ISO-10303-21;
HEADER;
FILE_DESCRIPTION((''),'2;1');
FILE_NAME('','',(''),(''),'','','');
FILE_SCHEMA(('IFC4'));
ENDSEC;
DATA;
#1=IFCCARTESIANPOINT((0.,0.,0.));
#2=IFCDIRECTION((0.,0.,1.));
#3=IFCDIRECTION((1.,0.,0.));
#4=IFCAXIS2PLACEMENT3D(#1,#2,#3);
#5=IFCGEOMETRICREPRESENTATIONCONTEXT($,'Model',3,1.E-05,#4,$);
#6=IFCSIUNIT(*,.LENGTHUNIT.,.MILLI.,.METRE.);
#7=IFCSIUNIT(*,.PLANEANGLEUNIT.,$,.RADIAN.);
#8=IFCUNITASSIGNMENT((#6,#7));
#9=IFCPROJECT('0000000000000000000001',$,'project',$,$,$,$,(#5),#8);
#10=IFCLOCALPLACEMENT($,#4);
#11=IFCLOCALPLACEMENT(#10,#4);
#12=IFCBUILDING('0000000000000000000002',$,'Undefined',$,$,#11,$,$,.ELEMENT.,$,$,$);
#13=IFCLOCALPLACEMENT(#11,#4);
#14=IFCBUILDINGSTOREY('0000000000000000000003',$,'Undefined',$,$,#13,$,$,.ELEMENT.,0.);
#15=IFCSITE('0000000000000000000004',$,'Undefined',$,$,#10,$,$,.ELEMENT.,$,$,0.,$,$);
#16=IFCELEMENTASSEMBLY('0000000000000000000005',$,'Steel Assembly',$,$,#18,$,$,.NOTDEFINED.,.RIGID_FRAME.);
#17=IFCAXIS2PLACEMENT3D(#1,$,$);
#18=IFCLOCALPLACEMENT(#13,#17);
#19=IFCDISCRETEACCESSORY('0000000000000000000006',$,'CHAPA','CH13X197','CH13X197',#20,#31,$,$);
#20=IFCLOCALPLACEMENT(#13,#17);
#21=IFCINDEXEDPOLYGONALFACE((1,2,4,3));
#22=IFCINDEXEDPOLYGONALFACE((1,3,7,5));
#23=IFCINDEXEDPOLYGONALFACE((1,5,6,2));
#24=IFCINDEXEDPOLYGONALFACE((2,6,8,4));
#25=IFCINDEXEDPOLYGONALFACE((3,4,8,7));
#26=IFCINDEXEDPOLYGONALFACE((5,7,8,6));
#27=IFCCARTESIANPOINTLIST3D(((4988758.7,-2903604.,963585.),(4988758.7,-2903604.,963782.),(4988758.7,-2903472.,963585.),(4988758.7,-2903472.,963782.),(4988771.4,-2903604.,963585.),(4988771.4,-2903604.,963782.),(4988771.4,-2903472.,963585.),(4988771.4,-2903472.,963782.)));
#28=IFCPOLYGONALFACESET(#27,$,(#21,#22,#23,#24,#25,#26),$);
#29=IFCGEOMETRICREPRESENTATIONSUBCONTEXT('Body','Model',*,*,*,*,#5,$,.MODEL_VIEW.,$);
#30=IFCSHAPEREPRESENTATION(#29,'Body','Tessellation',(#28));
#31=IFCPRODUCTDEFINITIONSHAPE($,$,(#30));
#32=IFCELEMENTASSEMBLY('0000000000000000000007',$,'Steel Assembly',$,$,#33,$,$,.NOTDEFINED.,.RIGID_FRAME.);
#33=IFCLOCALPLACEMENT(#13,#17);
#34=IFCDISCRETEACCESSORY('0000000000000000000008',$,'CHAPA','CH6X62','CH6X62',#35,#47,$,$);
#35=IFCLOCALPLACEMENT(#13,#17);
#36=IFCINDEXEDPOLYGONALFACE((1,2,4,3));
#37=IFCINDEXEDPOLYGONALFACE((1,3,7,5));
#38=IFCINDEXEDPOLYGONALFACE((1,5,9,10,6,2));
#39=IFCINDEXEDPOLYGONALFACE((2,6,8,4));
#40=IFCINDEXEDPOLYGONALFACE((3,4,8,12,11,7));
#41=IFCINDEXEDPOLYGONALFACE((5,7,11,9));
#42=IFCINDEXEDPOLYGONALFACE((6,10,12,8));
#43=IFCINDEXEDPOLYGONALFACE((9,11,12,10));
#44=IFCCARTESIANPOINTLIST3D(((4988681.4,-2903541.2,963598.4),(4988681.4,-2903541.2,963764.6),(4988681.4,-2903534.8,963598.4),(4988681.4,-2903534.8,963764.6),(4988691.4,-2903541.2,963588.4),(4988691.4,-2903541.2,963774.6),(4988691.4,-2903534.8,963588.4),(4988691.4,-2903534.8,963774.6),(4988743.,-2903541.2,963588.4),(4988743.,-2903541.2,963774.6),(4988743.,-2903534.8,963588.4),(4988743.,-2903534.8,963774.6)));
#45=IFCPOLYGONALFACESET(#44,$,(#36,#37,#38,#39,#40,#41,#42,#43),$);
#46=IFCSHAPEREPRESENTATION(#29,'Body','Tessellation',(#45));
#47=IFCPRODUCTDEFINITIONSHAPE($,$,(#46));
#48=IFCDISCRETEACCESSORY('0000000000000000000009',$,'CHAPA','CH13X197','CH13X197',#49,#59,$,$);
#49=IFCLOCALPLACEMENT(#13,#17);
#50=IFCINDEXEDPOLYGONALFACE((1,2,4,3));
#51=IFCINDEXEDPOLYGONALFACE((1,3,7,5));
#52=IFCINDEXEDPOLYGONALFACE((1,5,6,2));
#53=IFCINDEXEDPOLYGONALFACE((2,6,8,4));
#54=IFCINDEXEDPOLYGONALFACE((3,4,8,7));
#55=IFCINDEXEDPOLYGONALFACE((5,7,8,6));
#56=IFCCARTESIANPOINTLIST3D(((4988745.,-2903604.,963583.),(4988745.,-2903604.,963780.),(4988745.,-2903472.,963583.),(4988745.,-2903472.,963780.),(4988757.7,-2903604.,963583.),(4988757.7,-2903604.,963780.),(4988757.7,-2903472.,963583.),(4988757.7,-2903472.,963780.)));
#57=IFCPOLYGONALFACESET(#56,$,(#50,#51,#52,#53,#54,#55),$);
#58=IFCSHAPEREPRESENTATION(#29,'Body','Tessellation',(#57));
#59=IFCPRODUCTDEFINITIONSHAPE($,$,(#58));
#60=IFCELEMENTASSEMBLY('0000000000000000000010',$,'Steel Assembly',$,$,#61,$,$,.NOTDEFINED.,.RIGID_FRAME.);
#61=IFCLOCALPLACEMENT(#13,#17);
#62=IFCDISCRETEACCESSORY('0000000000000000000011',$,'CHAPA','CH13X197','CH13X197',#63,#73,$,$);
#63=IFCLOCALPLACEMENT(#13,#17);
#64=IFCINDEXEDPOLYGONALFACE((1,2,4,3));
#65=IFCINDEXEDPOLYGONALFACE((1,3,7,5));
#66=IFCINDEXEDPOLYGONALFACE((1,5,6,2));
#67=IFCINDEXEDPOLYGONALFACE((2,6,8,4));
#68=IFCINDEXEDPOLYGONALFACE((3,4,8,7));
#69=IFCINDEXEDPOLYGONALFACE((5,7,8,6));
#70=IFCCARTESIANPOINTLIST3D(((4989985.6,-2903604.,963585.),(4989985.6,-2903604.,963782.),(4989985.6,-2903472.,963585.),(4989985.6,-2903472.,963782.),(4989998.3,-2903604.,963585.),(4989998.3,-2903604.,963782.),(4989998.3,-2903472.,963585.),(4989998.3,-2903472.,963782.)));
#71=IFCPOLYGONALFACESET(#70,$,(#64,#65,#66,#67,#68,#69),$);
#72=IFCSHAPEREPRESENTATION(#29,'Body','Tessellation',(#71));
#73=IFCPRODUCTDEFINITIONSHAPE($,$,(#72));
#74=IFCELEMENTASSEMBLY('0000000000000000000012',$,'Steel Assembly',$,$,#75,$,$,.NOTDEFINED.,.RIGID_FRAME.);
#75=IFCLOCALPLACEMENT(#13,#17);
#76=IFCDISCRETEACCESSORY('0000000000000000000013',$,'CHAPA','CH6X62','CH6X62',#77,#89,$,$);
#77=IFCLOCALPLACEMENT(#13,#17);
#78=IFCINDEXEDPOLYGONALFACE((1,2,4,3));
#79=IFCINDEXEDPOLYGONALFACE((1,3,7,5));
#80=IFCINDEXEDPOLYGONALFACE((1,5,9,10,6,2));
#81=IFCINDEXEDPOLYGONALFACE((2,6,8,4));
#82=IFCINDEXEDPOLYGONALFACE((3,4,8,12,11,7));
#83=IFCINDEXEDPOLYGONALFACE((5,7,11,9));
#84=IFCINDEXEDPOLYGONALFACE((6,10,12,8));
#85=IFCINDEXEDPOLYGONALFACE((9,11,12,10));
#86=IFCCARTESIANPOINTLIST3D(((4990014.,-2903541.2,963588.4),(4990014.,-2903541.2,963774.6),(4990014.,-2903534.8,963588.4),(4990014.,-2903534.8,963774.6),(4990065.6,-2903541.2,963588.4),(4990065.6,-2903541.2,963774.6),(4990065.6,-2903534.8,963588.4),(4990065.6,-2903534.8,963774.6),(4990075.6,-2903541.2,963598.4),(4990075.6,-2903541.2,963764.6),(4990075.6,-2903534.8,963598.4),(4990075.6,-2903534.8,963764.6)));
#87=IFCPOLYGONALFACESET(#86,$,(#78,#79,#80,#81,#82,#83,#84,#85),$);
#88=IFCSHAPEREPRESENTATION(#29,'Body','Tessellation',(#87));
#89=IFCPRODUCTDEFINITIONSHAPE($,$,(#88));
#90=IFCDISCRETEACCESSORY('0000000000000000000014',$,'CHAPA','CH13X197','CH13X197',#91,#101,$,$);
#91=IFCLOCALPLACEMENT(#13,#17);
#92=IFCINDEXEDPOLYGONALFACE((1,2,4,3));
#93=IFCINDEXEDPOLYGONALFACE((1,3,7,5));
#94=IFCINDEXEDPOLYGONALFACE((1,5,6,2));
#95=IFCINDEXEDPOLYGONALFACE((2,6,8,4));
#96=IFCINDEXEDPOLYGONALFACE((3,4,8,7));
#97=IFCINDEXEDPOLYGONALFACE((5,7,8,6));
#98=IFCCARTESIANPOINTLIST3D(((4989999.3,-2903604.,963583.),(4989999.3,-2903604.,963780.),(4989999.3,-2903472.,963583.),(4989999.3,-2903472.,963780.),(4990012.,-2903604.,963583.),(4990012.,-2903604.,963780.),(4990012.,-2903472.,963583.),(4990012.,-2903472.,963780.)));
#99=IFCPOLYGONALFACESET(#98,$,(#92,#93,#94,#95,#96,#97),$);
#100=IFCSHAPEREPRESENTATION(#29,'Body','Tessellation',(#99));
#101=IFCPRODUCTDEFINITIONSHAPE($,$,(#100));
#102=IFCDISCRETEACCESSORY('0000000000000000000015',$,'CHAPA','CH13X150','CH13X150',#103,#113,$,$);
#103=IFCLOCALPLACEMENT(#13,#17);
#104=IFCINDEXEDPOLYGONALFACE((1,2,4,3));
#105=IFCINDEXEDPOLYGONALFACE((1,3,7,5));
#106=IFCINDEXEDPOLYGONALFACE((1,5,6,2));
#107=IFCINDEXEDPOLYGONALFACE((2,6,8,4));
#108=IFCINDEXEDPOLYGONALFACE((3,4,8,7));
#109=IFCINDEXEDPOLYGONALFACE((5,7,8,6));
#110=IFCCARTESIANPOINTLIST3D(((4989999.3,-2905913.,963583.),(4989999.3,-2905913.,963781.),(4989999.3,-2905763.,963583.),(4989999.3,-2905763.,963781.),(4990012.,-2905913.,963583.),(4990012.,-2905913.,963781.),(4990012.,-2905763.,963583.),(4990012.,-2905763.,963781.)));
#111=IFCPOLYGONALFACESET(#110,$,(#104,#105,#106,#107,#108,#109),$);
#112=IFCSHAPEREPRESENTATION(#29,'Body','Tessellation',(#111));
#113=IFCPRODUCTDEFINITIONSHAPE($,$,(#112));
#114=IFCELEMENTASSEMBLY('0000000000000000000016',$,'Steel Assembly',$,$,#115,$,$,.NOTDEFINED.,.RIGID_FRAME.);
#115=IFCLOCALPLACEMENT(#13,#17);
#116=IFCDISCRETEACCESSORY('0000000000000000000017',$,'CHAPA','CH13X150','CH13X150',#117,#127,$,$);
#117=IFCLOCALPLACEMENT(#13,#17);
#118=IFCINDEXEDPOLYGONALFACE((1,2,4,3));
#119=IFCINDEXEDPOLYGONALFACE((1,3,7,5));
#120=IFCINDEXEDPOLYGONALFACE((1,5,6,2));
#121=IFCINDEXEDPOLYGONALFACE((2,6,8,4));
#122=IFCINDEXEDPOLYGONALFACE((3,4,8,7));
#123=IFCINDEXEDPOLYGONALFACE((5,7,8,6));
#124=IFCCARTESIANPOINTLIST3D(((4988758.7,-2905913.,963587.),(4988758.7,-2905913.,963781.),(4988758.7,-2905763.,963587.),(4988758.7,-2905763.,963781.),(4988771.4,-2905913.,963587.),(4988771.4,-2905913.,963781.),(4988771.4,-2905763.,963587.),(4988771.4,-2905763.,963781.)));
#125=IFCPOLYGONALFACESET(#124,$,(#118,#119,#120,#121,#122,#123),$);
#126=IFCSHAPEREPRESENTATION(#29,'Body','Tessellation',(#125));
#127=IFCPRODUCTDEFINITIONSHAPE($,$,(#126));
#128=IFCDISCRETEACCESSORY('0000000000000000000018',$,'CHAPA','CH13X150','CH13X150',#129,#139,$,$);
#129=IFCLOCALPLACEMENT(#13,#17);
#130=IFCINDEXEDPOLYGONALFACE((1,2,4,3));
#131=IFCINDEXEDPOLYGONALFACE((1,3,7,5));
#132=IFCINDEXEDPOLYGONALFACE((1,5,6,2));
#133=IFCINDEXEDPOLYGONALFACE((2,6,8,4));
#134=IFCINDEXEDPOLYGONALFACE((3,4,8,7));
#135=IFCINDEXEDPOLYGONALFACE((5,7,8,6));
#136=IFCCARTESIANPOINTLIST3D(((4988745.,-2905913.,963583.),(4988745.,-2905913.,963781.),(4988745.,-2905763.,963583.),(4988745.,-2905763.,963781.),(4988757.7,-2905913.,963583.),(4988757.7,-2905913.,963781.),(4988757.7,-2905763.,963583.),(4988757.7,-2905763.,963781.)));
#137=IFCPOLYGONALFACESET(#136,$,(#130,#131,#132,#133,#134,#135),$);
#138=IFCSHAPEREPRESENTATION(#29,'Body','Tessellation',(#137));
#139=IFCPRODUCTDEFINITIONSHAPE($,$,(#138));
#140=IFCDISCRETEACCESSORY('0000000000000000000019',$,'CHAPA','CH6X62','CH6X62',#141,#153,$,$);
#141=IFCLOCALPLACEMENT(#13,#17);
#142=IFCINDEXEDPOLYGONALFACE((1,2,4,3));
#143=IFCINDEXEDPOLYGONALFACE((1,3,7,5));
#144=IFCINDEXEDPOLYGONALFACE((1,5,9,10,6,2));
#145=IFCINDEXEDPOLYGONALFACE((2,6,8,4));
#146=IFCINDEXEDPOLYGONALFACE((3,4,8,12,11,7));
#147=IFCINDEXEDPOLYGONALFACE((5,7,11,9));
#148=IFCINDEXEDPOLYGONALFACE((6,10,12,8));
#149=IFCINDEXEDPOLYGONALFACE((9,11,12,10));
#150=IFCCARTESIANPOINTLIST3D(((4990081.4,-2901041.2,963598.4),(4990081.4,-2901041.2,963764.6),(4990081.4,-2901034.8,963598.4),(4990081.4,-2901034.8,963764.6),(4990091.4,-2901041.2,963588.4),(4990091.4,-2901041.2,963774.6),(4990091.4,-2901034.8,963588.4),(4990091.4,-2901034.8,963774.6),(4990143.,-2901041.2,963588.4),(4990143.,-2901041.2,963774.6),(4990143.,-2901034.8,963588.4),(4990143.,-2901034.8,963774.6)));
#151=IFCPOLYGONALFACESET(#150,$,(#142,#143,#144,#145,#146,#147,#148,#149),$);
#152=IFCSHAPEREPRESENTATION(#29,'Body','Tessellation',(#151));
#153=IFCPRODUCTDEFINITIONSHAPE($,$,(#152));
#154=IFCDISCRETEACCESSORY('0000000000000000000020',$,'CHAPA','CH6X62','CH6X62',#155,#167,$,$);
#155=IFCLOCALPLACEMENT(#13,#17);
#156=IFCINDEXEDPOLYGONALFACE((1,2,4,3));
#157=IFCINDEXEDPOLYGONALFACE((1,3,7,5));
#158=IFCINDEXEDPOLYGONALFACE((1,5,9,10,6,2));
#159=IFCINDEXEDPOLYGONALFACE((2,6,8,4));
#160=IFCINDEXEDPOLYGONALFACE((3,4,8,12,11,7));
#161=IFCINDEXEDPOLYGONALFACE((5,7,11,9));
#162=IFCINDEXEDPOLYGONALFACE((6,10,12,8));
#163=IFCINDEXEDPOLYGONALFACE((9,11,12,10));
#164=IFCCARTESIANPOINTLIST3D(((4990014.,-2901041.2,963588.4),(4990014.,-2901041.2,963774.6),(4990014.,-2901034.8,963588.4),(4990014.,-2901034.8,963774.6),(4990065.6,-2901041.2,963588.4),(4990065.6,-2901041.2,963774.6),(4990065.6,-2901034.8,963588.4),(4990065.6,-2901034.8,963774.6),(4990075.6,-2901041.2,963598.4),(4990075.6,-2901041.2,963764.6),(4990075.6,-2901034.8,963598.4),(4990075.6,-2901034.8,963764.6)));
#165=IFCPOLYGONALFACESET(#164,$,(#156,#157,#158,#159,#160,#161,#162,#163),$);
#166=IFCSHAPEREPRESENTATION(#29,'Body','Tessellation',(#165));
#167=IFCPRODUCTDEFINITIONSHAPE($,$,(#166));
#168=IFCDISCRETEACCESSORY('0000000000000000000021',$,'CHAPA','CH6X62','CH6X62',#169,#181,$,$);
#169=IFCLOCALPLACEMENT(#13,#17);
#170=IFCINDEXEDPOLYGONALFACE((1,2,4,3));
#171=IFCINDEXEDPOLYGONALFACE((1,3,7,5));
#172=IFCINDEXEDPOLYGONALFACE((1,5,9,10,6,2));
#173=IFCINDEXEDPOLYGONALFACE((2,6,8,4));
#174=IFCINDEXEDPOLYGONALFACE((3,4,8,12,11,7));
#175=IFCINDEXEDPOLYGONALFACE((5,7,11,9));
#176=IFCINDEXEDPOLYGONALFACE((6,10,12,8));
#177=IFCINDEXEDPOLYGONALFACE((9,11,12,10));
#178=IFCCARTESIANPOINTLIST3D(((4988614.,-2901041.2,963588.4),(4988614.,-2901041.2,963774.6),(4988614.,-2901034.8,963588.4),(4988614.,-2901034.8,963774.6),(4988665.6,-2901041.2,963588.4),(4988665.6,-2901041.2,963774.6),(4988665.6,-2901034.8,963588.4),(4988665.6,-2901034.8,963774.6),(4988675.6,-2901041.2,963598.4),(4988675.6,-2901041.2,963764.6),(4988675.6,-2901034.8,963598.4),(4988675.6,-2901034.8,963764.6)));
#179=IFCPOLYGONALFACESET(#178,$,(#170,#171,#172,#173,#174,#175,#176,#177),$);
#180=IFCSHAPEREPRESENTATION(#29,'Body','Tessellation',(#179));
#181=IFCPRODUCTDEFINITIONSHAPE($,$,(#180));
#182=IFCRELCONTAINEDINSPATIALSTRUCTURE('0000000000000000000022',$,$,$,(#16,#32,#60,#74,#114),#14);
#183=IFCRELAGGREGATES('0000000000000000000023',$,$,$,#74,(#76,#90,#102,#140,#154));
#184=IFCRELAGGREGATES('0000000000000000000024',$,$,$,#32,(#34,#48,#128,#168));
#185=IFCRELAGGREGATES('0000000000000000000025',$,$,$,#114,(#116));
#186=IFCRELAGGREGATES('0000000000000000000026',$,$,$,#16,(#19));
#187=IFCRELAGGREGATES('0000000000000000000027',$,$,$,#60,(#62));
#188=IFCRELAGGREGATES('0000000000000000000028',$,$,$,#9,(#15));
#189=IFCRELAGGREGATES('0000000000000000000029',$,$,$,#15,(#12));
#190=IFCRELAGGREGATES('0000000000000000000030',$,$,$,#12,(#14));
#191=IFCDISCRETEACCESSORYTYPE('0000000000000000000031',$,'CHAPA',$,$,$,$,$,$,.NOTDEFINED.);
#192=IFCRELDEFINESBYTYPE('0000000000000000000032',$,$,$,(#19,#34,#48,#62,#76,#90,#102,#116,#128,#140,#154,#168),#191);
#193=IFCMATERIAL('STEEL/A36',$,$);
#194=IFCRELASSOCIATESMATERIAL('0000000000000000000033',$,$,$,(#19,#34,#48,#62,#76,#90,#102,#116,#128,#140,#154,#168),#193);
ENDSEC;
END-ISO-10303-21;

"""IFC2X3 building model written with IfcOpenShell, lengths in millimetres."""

from ifc_helpers import new_model, si_unit, frame, origin_with_axes, place, context, subcontext, project, spatial, polyline, outline, extrude, material, type_object, element, aggregate, save


model = new_model("IFC2X3")

# Units and contexts
model_context = context("Model", 3, precision=1e-05, world=origin_with_axes())
body_context = subcontext(model_context, "Body", "Model", "MODEL_VIEW")
ifc_project = project(units=[si_unit("LENGTHUNIT", "METRE", prefix="MILLI"), si_unit("PLANEANGLEUNIT", "RADIAN")], contexts=[model_context])

# Site, building, storey
site_placement = place(None, origin_with_axes())
site = spatial("IfcSite", under=ifc_project, at=site_placement, Name="Undefined", CompositionType="ELEMENT", RefElevation=0.0)
building_placement = place(site_placement, origin_with_axes())
building = spatial("IfcBuilding", under=site, at=building_placement, Name="Undefined", CompositionType="ELEMENT")
storey_placement = place(building_placement, origin_with_axes())
storey = spatial("IfcBuildingStorey", under=building, at=storey_placement, Name="Undefined", CompositionType="ELEMENT", Elevation=0.0)

# Element assembly, discrete accessory
assembly_1_placement = place(storey_placement, origin_with_axes())
assembly_1 = element("IfcElementAssembly", 1, at=assembly_1_placement, inside=storey, Name="Steel Assembly", AssemblyPlace="NOTDEFINED", PredefinedType="RIGID_FRAME")
ifc_material = material(Name="STEEL/A36")
discrete_accessory_type = type_object("IfcDiscreteAccessoryType", Name="CHAPA")
discrete_accessory_1_placement = place(assembly_1_placement, frame((4988765.0, -2903538.0, 963782.0), z_axis=(1.0, 0.0, 0.0), x_axis=(0.0, 0.0, -1.0)))
discrete_accessory_1 = element("IfcDiscreteAccessory", 2, at=discrete_accessory_1_placement, type_object=discrete_accessory_type, material=ifc_material, Name="CHAPA", Description="CH13X197", ObjectType="CH13X197", context=body_context, shape_type="SweptSolid", body=[
    extrude(outline(polyline([(197.0, -66.0), (0.0, -66.0), (0.0, 66.0), (197.0, 66.0), (197.0, -66.0)])), frame((0.0, 0.0, -6.3), z_axis=(0.0, 0.0, 1.0), x_axis=(1.0, 0.0, 0.0)), (0.0, 0.0, 1.0), 12.7),
])

# Element assembly, discrete accessories
assembly_2_placement = place(storey_placement, origin_with_axes())
assembly_2 = element("IfcElementAssembly", 3, at=assembly_2_placement, inside=storey, Name="Steel Assembly", AssemblyPlace="NOTDEFINED", PredefinedType="RIGID_FRAME")
discrete_accessory_2_placement = place(assembly_2_placement, frame((4988681.4, -2903538.0, 963774.6), z_axis=(0.0, 1.0, 0.0), x_axis=(1.0, 0.0, 0.0)))
discrete_accessory_2 = element("IfcDiscreteAccessory", 4, at=discrete_accessory_2_placement, type_object=discrete_accessory_type, material=ifc_material, Name="CHAPA", Description="CH6X62", ObjectType="CH6X62", context=body_context, shape_type="SweptSolid", body=[
    extrude(outline(polyline([(0.0, 10.0), (10.0, 0.0), (61.6, 0.0), (61.6, 186.2), (10.0, 186.2), (0.0, 176.2), (0.0, 10.0)])), frame((0.0, 0.0, -3.2), z_axis=(0.0, 0.0, 1.0), x_axis=(1.0, 0.0, 0.0)), (0.0, 0.0, 1.0), 6.4),
])
discrete_accessory_3_placement = place(assembly_2_placement, frame((4988751.3, -2903538.0, 963780.0), z_axis=(1.0, 0.0, 0.0), x_axis=(0.0, 0.0, -1.0)))
discrete_accessory_3 = element("IfcDiscreteAccessory", 5, at=discrete_accessory_3_placement, type_object=discrete_accessory_type, material=ifc_material, Name="CHAPA", Description="CH13X197", ObjectType="CH13X197", context=body_context, shape_type="SweptSolid", body=[
    extrude(outline(polyline([(197.0, -66.0), (0.0, -66.0), (0.0, 66.0), (197.0, 66.0), (197.0, -66.0)])), frame((0.0, 0.0, -6.3), z_axis=(0.0, 0.0, 1.0), x_axis=(1.0, 0.0, 0.0)), (0.0, 0.0, 1.0), 12.7),
])

# Element assembly, discrete accessory
assembly_3_placement = place(storey_placement, origin_with_axes())
assembly_3 = element("IfcElementAssembly", 6, at=assembly_3_placement, inside=storey, Name="Steel Assembly", AssemblyPlace="NOTDEFINED", PredefinedType="RIGID_FRAME")
discrete_accessory_4_placement = place(assembly_3_placement, frame((4989991.9, -2903538.0, 963782.0), z_axis=(-1.0, 0.0, 0.0), x_axis=(0.0, 0.0, -1.0)))
discrete_accessory_4 = element("IfcDiscreteAccessory", 7, at=discrete_accessory_4_placement, type_object=discrete_accessory_type, material=ifc_material, Name="CHAPA", Description="CH13X197", ObjectType="CH13X197", context=body_context, shape_type="SweptSolid", body=[
    extrude(outline(polyline([(197.0, 66.0), (197.0, -66.0), (0.0, -66.0), (0.0, 66.0), (197.0, 66.0)])), frame((0.0, 0.0, -6.3), z_axis=(0.0, 0.0, 1.0), x_axis=(1.0, 0.0, 0.0)), (0.0, 0.0, 1.0), 12.7),
])

# Element assembly, discrete accessories
assembly_4_placement = place(storey_placement, origin_with_axes())
assembly_4 = element("IfcElementAssembly", 8, at=assembly_4_placement, inside=storey, Name="Steel Assembly", AssemblyPlace="NOTDEFINED", PredefinedType="RIGID_FRAME")
discrete_accessory_5_placement = place(assembly_4_placement, frame((4990075.6, -2903538.0, 963774.6), z_axis=(0.0, -1.0, 0.0), x_axis=(-1.0, 0.0, 0.0)))
discrete_accessory_5 = element("IfcDiscreteAccessory", 9, at=discrete_accessory_5_placement, type_object=discrete_accessory_type, material=ifc_material, Name="CHAPA", Description="CH6X62", ObjectType="CH6X62", context=body_context, shape_type="SweptSolid", body=[
    extrude(outline(polyline([(0.0, 10.0), (10.0, 0.0), (61.6, 0.0), (61.6, 186.2), (10.0, 186.2), (0.0, 176.2), (0.0, 10.0)])), frame((0.0, 0.0, -3.2), z_axis=(0.0, 0.0, 1.0), x_axis=(1.0, 0.0, 0.0)), (0.0, 0.0, 1.0), 6.4),
])
discrete_accessory_6_placement = place(assembly_4_placement, frame((4990005.6, -2903538.0, 963780.0), z_axis=(-1.0, 0.0, 0.0), x_axis=(0.0, 0.0, -1.0)))
discrete_accessory_6 = element("IfcDiscreteAccessory", 10, at=discrete_accessory_6_placement, type_object=discrete_accessory_type, material=ifc_material, Name="CHAPA", Description="CH13X197", ObjectType="CH13X197", context=body_context, shape_type="SweptSolid", body=[
    extrude(outline(polyline([(197.0, 66.0), (197.0, -66.0), (0.0, -66.0), (0.0, 66.0), (197.0, 66.0)])), frame((0.0, 0.0, -6.3), z_axis=(0.0, 0.0, 1.0), x_axis=(1.0, 0.0, 0.0)), (0.0, 0.0, 1.0), 12.7),
])
discrete_accessory_7_placement = place(assembly_4_placement, frame((4990005.6, -2905838.0, 963781.0), z_axis=(-1.0, 0.0, 0.0), x_axis=(0.0, 0.0, -1.0)))
discrete_accessory_7 = element("IfcDiscreteAccessory", 11, at=discrete_accessory_7_placement, type_object=discrete_accessory_type, material=ifc_material, Name="CHAPA", Description="CH13X150", ObjectType="CH13X150", context=body_context, shape_type="SweptSolid", body=[
    extrude(outline(polyline([(198.0, 75.0), (198.0, -75.0), (0.0, -75.0), (0.0, 75.0), (198.0, 75.0)])), frame((0.0, 0.0, -6.3), z_axis=(0.0, 0.0, 1.0), x_axis=(1.0, 0.0, 0.0)), (0.0, 0.0, 1.0), 12.7),
])

# Element assembly, discrete accessory
assembly_5_placement = place(storey_placement, origin_with_axes())
assembly_5 = element("IfcElementAssembly", 12, at=assembly_5_placement, inside=storey, Name="Steel Assembly", AssemblyPlace="NOTDEFINED", PredefinedType="RIGID_FRAME")
discrete_accessory_8_placement = place(assembly_5_placement, frame((4988765.0, -2905838.0, 963781.0), z_axis=(1.0, 0.0, 0.0), x_axis=(0.0, 0.0, -1.0)))
discrete_accessory_8 = element("IfcDiscreteAccessory", 13, at=discrete_accessory_8_placement, type_object=discrete_accessory_type, material=ifc_material, Name="CHAPA", Description="CH13X150", ObjectType="CH13X150", context=body_context, shape_type="SweptSolid", body=[
    extrude(outline(polyline([(194.0, -75.0), (0.0, -75.0), (0.0, 75.0), (194.0, 75.0), (194.0, -75.0)])), frame((0.0, 0.0, -6.3), z_axis=(0.0, 0.0, 1.0), x_axis=(1.0, 0.0, 0.0)), (0.0, 0.0, 1.0), 12.7),
])

# Discrete accessories
discrete_accessory_9_placement = place(assembly_2_placement, frame((4988751.3, -2905838.0, 963781.0), z_axis=(1.0, 0.0, 0.0), x_axis=(0.0, 0.0, -1.0)))
discrete_accessory_9 = element("IfcDiscreteAccessory", 14, at=discrete_accessory_9_placement, type_object=discrete_accessory_type, material=ifc_material, Name="CHAPA", Description="CH13X150", ObjectType="CH13X150", context=body_context, shape_type="SweptSolid", body=[
    extrude(outline(polyline([(198.0, -75.0), (0.0, -75.0), (0.0, 75.0), (198.0, 75.0), (198.0, -75.0)])), frame((0.0, 0.0, -6.3), z_axis=(0.0, 0.0, 1.0), x_axis=(1.0, 0.0, 0.0)), (0.0, 0.0, 1.0), 12.7),
])
discrete_accessory_10_placement = place(assembly_4_placement, frame((4990081.4, -2901038.0, 963774.6), z_axis=(0.0, 1.0, 0.0), x_axis=(1.0, 0.0, 0.0)))
discrete_accessory_10 = element("IfcDiscreteAccessory", 15, at=discrete_accessory_10_placement, type_object=discrete_accessory_type, material=ifc_material, Name="CHAPA", Description="CH6X62", ObjectType="CH6X62", context=body_context, shape_type="SweptSolid", body=[
    extrude(outline(polyline([(0.0, 10.0), (10.0, 0.0), (61.6, 0.0), (61.6, 186.2), (10.0, 186.2), (0.0, 176.2), (0.0, 10.0)])), frame((0.0, 0.0, -3.2), z_axis=(0.0, 0.0, 1.0), x_axis=(1.0, 0.0, 0.0)), (0.0, 0.0, 1.0), 6.4),
])
discrete_accessory_11_placement = place(assembly_4_placement, frame((4990075.6, -2901038.0, 963774.6), z_axis=(0.0, -1.0, 0.0), x_axis=(-1.0, 0.0, 0.0)))
discrete_accessory_11 = element("IfcDiscreteAccessory", 16, at=discrete_accessory_11_placement, type_object=discrete_accessory_type, material=ifc_material, Name="CHAPA", Description="CH6X62", ObjectType="CH6X62", context=body_context, shape_type="SweptSolid", body=[
    extrude(outline(polyline([(0.0, 10.0), (10.0, 0.0), (61.6, 0.0), (61.6, 186.2), (10.0, 186.2), (0.0, 176.2), (0.0, 10.0)])), frame((0.0, 0.0, -3.2), z_axis=(0.0, 0.0, 1.0), x_axis=(1.0, 0.0, 0.0)), (0.0, 0.0, 1.0), 6.4),
])
aggregate(assembly_4, [discrete_accessory_5, discrete_accessory_6, discrete_accessory_7, discrete_accessory_10, discrete_accessory_11])
discrete_accessory_12_placement = place(assembly_2_placement, frame((4988675.6, -2901038.0, 963774.6), z_axis=(0.0, -1.0, 0.0), x_axis=(-1.0, 0.0, 0.0)))
discrete_accessory_12 = element("IfcDiscreteAccessory", 17, at=discrete_accessory_12_placement, type_object=discrete_accessory_type, material=ifc_material, Name="CHAPA", Description="CH6X62", ObjectType="CH6X62", context=body_context, shape_type="SweptSolid", body=[
    extrude(outline(polyline([(0.0, 10.0), (10.0, 0.0), (61.6, 0.0), (61.6, 186.2), (10.0, 186.2), (0.0, 176.2), (0.0, 10.0)])), frame((0.0, 0.0, -3.2), z_axis=(0.0, 0.0, 1.0), x_axis=(1.0, 0.0, 0.0)), (0.0, 0.0, 1.0), 6.4),
])
aggregate(assembly_2, [discrete_accessory_2, discrete_accessory_3, discrete_accessory_9, discrete_accessory_12])

aggregate(assembly_5, [discrete_accessory_8])
aggregate(assembly_1, [discrete_accessory_1])
aggregate(assembly_3, [discrete_accessory_4])

save(model, "model.ifc")
